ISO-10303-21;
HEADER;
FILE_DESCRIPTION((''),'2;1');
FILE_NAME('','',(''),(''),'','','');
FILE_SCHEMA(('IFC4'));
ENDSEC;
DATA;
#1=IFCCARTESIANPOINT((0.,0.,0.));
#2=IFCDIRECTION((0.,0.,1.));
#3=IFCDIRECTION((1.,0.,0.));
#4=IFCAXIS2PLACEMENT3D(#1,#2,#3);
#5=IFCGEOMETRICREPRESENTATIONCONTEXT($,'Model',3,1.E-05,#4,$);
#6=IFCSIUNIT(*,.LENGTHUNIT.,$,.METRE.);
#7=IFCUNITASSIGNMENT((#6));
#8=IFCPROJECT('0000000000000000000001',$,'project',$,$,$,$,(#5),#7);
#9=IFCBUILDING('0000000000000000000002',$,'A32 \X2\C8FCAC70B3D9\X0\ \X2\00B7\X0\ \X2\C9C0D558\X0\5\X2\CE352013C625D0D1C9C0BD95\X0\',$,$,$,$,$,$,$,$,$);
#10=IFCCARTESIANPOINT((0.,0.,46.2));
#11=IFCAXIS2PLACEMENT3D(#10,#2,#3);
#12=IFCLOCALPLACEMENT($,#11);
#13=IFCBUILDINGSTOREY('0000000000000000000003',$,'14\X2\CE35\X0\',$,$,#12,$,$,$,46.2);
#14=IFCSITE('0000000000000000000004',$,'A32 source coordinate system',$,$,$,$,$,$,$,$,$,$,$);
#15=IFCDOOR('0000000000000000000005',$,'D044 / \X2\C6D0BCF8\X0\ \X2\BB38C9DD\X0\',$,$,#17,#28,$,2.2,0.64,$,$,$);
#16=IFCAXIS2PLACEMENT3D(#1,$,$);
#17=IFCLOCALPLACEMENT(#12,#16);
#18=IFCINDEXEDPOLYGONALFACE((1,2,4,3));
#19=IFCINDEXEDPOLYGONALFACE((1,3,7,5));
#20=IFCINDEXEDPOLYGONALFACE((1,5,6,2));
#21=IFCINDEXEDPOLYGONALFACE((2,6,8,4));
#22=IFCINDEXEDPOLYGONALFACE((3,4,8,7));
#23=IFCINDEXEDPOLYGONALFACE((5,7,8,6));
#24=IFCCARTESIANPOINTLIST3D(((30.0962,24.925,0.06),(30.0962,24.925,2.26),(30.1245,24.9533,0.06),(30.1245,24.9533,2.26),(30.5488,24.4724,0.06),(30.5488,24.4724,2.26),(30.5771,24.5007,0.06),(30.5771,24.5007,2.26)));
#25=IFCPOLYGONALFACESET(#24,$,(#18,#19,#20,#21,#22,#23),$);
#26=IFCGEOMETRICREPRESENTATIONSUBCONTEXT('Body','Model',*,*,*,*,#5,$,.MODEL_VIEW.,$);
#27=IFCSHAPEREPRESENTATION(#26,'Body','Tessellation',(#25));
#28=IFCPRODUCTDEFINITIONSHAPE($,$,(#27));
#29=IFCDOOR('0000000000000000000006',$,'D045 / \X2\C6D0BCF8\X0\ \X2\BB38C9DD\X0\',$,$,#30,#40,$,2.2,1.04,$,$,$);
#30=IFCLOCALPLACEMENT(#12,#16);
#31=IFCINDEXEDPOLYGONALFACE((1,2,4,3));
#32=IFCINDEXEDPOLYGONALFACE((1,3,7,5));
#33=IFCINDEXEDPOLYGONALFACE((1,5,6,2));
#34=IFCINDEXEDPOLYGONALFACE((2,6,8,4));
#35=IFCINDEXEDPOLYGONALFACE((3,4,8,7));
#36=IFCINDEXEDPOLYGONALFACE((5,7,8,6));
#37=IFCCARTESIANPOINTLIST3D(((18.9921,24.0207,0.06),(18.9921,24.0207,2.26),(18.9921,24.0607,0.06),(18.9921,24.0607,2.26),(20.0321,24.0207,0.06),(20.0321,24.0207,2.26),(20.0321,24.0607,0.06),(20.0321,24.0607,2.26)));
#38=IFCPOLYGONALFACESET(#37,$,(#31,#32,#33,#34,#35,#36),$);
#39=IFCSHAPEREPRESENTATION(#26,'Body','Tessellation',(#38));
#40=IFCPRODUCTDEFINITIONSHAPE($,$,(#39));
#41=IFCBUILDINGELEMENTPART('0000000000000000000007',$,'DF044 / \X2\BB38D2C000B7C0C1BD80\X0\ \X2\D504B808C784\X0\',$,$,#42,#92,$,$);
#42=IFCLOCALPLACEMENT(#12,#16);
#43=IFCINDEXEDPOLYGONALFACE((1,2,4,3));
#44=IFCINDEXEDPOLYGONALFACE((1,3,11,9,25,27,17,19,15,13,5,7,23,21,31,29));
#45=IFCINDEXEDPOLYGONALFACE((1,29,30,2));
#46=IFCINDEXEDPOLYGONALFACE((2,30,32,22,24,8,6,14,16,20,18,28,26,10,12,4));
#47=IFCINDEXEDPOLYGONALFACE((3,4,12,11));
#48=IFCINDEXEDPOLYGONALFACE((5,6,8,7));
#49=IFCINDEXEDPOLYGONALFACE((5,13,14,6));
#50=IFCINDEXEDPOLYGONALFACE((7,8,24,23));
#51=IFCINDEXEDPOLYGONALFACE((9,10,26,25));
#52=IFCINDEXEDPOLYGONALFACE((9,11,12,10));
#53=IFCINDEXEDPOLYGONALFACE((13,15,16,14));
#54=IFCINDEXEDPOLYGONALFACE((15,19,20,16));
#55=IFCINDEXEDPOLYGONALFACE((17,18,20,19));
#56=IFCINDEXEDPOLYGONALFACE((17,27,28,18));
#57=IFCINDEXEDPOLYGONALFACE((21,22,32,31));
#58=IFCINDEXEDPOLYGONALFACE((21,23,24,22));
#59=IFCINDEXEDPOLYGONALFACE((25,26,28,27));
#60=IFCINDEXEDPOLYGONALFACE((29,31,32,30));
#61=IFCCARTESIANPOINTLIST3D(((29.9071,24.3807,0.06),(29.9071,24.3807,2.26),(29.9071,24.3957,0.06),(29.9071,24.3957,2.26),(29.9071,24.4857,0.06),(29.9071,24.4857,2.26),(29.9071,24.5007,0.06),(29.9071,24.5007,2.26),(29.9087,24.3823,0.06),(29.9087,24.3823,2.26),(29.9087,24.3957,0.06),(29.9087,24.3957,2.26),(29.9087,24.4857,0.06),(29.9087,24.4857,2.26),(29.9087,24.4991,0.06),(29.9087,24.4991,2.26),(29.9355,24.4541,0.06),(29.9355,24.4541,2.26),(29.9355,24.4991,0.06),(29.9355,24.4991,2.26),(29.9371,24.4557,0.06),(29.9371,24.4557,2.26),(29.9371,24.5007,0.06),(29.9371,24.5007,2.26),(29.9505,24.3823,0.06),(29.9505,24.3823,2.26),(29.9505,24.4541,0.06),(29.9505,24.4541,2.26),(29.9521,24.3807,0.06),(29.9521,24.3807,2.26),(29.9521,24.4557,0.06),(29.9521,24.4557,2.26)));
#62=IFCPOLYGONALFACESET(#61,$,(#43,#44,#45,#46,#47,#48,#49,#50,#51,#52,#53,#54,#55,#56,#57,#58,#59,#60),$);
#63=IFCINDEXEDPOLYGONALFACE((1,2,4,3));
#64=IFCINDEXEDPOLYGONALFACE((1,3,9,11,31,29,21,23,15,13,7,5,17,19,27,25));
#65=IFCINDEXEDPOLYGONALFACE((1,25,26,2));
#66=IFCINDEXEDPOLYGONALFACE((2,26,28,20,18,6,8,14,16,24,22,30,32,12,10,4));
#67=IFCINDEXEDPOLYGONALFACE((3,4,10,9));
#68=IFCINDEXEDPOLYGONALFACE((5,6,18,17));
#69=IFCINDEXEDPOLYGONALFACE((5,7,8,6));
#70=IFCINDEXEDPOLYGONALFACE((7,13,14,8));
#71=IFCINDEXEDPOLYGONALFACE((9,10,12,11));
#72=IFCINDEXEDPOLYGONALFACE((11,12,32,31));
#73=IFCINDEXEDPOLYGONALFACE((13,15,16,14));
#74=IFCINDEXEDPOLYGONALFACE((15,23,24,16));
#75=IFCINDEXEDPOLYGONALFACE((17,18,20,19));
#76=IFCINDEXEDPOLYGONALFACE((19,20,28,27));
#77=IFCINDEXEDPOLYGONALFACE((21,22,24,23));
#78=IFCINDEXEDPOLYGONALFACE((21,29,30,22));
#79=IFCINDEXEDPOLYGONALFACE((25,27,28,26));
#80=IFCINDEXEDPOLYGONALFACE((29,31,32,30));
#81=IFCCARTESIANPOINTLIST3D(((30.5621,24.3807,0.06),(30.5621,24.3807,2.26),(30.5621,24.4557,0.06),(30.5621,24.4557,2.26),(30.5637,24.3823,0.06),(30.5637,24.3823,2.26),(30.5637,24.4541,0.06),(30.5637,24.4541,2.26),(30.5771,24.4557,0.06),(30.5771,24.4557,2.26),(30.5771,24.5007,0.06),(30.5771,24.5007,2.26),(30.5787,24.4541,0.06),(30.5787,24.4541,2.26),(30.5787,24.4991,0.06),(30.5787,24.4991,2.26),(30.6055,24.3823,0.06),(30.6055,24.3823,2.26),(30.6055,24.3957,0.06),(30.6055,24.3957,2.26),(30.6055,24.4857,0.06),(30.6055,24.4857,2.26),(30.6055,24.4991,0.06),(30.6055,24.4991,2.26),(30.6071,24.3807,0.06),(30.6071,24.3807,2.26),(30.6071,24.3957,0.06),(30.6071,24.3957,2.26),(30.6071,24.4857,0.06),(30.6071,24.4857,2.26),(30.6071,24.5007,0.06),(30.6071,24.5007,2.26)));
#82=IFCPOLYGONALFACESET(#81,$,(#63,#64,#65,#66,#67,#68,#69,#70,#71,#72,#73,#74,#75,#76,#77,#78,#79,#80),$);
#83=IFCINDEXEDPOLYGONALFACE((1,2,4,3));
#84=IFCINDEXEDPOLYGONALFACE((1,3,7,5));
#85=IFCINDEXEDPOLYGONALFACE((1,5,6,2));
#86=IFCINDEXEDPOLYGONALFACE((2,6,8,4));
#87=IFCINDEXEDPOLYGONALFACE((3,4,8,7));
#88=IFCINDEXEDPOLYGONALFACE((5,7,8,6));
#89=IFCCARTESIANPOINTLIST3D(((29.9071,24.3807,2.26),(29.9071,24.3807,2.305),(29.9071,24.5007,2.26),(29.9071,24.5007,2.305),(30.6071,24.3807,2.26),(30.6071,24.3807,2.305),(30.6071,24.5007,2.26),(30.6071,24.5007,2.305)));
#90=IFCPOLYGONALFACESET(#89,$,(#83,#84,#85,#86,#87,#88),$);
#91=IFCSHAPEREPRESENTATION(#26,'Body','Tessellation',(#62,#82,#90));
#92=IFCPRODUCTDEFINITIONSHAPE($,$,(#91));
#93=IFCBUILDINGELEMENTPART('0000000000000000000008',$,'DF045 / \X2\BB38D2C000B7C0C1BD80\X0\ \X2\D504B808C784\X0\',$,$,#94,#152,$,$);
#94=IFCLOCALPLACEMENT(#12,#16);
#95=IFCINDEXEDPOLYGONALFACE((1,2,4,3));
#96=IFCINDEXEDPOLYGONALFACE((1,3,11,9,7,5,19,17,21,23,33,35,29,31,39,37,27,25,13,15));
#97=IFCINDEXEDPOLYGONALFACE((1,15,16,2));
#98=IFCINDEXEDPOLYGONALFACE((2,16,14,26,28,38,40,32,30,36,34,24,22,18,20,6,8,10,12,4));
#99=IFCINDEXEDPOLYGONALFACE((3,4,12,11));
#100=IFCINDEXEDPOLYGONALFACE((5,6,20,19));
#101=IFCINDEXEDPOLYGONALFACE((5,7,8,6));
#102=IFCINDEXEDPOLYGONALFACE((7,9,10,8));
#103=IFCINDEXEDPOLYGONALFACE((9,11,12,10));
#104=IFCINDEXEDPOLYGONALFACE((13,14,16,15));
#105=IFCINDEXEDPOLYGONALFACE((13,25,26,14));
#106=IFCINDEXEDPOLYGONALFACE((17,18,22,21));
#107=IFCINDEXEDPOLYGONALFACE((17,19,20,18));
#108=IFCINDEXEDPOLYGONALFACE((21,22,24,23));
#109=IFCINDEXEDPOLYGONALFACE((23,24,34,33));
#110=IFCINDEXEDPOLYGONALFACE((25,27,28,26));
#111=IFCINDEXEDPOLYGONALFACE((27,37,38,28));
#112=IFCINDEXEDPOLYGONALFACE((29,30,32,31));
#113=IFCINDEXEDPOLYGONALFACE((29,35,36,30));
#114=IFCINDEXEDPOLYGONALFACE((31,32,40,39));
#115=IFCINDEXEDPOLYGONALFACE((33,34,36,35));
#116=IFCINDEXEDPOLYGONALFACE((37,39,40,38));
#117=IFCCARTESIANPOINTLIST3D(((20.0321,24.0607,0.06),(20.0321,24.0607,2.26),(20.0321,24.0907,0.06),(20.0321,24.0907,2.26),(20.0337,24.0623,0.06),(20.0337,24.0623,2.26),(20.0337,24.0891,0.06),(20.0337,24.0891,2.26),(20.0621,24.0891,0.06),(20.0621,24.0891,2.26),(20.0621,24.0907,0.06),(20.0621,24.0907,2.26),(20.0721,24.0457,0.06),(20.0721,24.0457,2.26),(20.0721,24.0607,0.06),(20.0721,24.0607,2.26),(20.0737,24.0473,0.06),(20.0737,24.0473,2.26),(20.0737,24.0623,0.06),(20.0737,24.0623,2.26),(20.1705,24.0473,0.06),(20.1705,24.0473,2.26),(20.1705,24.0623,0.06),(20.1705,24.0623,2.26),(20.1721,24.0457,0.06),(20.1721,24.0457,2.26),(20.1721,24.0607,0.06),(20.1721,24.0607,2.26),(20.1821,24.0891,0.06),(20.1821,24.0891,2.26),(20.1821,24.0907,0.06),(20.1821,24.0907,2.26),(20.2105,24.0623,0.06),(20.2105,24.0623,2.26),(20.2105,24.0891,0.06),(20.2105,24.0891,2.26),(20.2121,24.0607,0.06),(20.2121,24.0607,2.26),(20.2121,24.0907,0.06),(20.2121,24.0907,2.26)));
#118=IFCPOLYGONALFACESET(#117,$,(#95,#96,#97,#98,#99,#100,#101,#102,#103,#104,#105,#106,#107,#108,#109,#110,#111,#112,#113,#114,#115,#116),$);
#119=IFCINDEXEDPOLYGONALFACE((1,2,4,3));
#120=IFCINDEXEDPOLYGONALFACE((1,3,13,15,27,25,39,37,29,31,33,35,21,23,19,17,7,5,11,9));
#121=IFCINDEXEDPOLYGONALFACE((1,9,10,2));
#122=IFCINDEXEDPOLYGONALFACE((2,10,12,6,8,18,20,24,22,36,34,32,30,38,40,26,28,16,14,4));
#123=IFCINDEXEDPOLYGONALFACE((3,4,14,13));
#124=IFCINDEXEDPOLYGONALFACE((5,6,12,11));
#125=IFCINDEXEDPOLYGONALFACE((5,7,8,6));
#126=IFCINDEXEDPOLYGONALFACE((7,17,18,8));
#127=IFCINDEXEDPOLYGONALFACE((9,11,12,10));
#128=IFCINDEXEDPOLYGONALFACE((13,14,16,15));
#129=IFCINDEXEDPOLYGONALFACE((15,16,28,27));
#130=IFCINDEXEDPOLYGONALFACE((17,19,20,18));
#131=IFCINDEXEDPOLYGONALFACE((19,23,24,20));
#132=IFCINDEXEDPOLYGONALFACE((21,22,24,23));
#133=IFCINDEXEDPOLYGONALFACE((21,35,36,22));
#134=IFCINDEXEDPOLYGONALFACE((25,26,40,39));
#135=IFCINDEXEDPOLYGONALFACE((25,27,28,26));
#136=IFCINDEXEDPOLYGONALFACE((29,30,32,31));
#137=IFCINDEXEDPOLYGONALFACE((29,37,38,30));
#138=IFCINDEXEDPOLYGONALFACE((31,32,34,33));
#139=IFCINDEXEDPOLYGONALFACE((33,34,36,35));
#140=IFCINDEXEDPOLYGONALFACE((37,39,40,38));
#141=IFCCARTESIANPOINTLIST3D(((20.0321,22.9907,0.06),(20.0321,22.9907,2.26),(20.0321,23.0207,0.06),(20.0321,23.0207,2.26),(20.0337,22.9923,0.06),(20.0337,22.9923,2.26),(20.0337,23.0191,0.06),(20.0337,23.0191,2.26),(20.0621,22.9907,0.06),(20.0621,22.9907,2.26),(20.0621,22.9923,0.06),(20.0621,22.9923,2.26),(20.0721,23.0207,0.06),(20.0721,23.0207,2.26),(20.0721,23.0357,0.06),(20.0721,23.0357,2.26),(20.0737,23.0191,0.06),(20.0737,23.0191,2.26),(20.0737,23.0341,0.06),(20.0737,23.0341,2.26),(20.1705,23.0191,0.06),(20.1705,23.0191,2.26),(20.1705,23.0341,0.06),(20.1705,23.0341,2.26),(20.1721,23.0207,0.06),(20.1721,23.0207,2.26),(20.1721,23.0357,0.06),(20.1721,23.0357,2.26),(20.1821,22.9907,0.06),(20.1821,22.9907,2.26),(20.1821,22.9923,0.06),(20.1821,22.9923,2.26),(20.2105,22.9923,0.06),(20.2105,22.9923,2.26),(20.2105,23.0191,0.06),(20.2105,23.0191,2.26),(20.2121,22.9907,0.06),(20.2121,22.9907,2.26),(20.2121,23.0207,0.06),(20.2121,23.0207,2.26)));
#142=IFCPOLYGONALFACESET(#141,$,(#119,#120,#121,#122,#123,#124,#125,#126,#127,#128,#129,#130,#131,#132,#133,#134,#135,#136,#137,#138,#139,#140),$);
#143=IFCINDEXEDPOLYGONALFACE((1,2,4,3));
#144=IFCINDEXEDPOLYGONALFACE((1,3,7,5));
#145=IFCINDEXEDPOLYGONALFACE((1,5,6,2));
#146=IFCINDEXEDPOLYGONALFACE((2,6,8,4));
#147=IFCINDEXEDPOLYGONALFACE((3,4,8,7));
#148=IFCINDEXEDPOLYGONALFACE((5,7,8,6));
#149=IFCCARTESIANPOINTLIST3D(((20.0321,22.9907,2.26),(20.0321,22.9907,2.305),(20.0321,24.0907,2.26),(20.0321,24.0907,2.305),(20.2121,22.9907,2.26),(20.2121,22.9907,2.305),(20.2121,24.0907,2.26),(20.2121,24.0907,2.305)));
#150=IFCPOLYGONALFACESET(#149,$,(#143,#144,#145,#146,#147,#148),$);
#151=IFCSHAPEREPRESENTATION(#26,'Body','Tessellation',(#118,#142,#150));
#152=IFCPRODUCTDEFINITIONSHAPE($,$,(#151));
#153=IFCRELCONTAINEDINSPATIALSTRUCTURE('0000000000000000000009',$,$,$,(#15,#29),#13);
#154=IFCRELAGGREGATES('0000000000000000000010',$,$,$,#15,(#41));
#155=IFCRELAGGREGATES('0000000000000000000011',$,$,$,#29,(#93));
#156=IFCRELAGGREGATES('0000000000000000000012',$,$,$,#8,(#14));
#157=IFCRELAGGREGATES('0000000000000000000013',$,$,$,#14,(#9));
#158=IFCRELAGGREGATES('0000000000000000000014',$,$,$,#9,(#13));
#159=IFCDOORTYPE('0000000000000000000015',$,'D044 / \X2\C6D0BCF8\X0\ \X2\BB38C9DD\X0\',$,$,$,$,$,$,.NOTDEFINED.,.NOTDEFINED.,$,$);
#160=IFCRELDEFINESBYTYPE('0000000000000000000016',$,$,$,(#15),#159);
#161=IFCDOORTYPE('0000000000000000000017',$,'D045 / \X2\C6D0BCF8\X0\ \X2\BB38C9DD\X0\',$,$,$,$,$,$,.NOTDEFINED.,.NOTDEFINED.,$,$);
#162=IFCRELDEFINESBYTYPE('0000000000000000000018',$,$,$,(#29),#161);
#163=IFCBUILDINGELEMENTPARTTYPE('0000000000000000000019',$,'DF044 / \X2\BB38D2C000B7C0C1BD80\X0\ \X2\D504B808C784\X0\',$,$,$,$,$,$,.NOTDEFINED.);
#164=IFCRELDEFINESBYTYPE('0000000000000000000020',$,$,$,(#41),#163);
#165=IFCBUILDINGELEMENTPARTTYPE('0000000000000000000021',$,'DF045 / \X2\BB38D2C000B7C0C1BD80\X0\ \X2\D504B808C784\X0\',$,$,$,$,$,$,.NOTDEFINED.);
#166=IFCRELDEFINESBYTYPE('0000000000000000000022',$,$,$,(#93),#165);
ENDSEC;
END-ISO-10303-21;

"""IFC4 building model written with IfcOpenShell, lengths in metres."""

from ifc_helpers import new_model, si_unit, frame, origin, origin_with_axes, place, context, subcontext, project, spatial, polyline, outline, extrude, source, transform, mapped, type_object, type_shapes, element, aggregate, save


model = new_model("IFC4")

# Units and contexts
model_context = context("Model", 3, precision=1e-05, world=origin_with_axes())
body_context = subcontext(model_context, "Body", "Model", "MODEL_VIEW")
ifc_project = project(units=[si_unit("LENGTHUNIT", "METRE")], contexts=[model_context])

# Site, building, storey
storey_placement = place(None, frame((0.0, 0.0, 46.2), z_axis=(0.0, 0.0, 1.0), x_axis=(1.0, 0.0, 0.0)))
site = spatial("IfcSite", under=ifc_project, Name="A32 source coordinate system")
building = spatial("IfcBuilding", under=site, Name="A32 주거동 · 지하5층–옥탑지붕")
storey = spatial("IfcBuildingStorey", under=building, at=storey_placement, Name="14층", Elevation=46.2)

# Doors
door_type_1 = type_object("IfcDoorType", Name="D044 / 원본 문짝", OperationType="NOTDEFINED", PredefinedType="NOTDEFINED")
shared_shape_1 = source(origin(), body_context, "Body", "SweptSolid", [
    extrude(outline(polyline([(30.5771, 24.5007), (30.5488, 24.4724), (30.0962, 24.925), (30.1245, 24.9533), (30.5771, 24.5007)])), frame((0.0, 0.0, 0.06)), (0.0, 0.0, 1.0), 2.2),
])
type_shapes(door_type_1, [shared_shape_1])
door_1_placement = place(storey_placement, origin_with_axes())
door_1 = element("IfcDoor", 1, at=door_1_placement, inside=storey, type_object=door_type_1, Name="D044 / 원본 문짝", OverallHeight=2.2, OverallWidth=0.64, context=body_context, shape_type="MappedRepresentation", body=[
    mapped(shared_shape_1, transform((0.0, 0.0, 0.0), scale=1.0)),
])
door_type_2 = type_object("IfcDoorType", Name="D045 / 원본 문짝", OperationType="NOTDEFINED", PredefinedType="NOTDEFINED")
shared_shape_2 = source(origin(), body_context, "Body", "SweptSolid", [
    extrude(outline(polyline([(20.0321, 24.0607), (20.0321, 24.0207), (18.9921, 24.0207), (18.9921, 24.0607), (20.0321, 24.0607)])), frame((0.0, 0.0, 0.06)), (0.0, 0.0, 1.0), 2.2),
])
type_shapes(door_type_2, [shared_shape_2])
door_2_placement = place(storey_placement, origin_with_axes())
door_2 = element("IfcDoor", 2, at=door_2_placement, inside=storey, type_object=door_type_2, Name="D045 / 원본 문짝", OverallHeight=2.2, OverallWidth=1.04, context=body_context, shape_type="MappedRepresentation", body=[
    mapped(shared_shape_2, transform((0.0, 0.0, 0.0), scale=1.0)),
])

# Building element parts
building_element_part_type_1 = type_object("IfcBuildingElementPartType", Name="DF044 / 문틀·상부 프레임", PredefinedType="NOTDEFINED")
shared_shape_3 = source(origin(), body_context, "Body", "SweptSolid", [
    extrude(outline(polyline([(29.9071, 24.4857), (29.9071, 24.5007), (29.9371, 24.5007), (29.9371, 24.4557), (29.9521, 24.4557), (29.9521, 24.3807), (29.9071, 24.3807), (29.9071, 24.3957), (29.9087, 24.3957), (29.9087, 24.3823), (29.9505, 24.3823), (29.9505, 24.4541), (29.9355, 24.4541), (29.9355, 24.4991), (29.9087, 24.4991), (29.9087, 24.4857), (29.9071, 24.4857)])), frame((0.0, 0.0, 0.06)), (0.0, 0.0, 1.0), 2.2),
    extrude(outline(polyline([(30.6055, 24.4991), (30.5787, 24.4991), (30.5787, 24.4541), (30.5637, 24.4541), (30.5637, 24.3823), (30.6055, 24.3823), (30.6055, 24.3957), (30.6071, 24.3957), (30.6071, 24.3807), (30.5621, 24.3807), (30.5621, 24.4557), (30.5771, 24.4557), (30.5771, 24.5007), (30.6071, 24.5007), (30.6071, 24.4857), (30.6055, 24.4857), (30.6055, 24.4991)])), frame((0.0, 0.0, 0.06)), (0.0, 0.0, 1.0), 2.2),
    extrude(outline(polyline([(29.9071, 24.3807), (29.9071, 24.5007), (30.6071, 24.5007), (30.6071, 24.3807), (29.9071, 24.3807)])), frame((0.0, 0.0, 2.26)), (0.0, 0.0, 1.0), 0.045),
])
type_shapes(building_element_part_type_1, [shared_shape_3])
building_element_part_1_placement = place(door_1_placement, origin_with_axes())
building_element_part_1 = element("IfcBuildingElementPart", 3, at=building_element_part_1_placement, type_object=building_element_part_type_1, Name="DF044 / 문틀·상부 프레임", context=body_context, shape_type="MappedRepresentation", body=[
    mapped(shared_shape_3, transform((0.0, 0.0, 0.0), scale=1.0)),
])
aggregate(door_1, [building_element_part_1])
building_element_part_type_2 = type_object("IfcBuildingElementPartType", Name="DF045 / 문틀·상부 프레임", PredefinedType="NOTDEFINED")
shared_shape_4 = source(origin(), body_context, "Body", "SweptSolid", [
    extrude(outline(polyline([(20.0337, 24.0891), (20.0337, 24.0623), (20.0737, 24.0623), (20.0737, 24.0473), (20.1705, 24.0473), (20.1705, 24.0623), (20.2105, 24.0623), (20.2105, 24.0891), (20.1821, 24.0891), (20.1821, 24.0907), (20.2121, 24.0907), (20.2121, 24.0607), (20.1721, 24.0607), (20.1721, 24.0457), (20.0721, 24.0457), (20.0721, 24.0607), (20.0321, 24.0607), (20.0321, 24.0907), (20.0621, 24.0907), (20.0621, 24.0891), (20.0337, 24.0891)])), frame((0.0, 0.0, 0.06)), (0.0, 0.0, 1.0), 2.2),
    extrude(outline(polyline([(20.0621, 22.9907), (20.0321, 22.9907), (20.0321, 23.0207), (20.0721, 23.0207), (20.0721, 23.0357), (20.1721, 23.0357), (20.1721, 23.0207), (20.2121, 23.0207), (20.2121, 22.9907), (20.1821, 22.9907), (20.1821, 22.9923), (20.2105, 22.9923), (20.2105, 23.0191), (20.1705, 23.0191), (20.1705, 23.0341), (20.0737, 23.0341), (20.0737, 23.0191), (20.0337, 23.0191), (20.0337, 22.9923), (20.0621, 22.9923), (20.0621, 22.9907)])), frame((0.0, 0.0, 0.06)), (0.0, 0.0, 1.0), 2.2),
    extrude(outline(polyline([(20.0321, 22.9907), (20.0321, 24.0907), (20.2121, 24.0907), (20.2121, 22.9907), (20.0321, 22.9907)])), frame((0.0, 0.0, 2.26)), (0.0, 0.0, 1.0), 0.045),
])
type_shapes(building_element_part_type_2, [shared_shape_4])
building_element_part_2_placement = place(door_2_placement, origin_with_axes())
building_element_part_2 = element("IfcBuildingElementPart", 4, at=building_element_part_2_placement, type_object=building_element_part_type_2, Name="DF045 / 문틀·상부 프레임", context=body_context, shape_type="MappedRepresentation", body=[
    mapped(shared_shape_4, transform((0.0, 0.0, 0.0), scale=1.0)),
])
aggregate(door_2, [building_element_part_2])

save(model, "model.ifc")
